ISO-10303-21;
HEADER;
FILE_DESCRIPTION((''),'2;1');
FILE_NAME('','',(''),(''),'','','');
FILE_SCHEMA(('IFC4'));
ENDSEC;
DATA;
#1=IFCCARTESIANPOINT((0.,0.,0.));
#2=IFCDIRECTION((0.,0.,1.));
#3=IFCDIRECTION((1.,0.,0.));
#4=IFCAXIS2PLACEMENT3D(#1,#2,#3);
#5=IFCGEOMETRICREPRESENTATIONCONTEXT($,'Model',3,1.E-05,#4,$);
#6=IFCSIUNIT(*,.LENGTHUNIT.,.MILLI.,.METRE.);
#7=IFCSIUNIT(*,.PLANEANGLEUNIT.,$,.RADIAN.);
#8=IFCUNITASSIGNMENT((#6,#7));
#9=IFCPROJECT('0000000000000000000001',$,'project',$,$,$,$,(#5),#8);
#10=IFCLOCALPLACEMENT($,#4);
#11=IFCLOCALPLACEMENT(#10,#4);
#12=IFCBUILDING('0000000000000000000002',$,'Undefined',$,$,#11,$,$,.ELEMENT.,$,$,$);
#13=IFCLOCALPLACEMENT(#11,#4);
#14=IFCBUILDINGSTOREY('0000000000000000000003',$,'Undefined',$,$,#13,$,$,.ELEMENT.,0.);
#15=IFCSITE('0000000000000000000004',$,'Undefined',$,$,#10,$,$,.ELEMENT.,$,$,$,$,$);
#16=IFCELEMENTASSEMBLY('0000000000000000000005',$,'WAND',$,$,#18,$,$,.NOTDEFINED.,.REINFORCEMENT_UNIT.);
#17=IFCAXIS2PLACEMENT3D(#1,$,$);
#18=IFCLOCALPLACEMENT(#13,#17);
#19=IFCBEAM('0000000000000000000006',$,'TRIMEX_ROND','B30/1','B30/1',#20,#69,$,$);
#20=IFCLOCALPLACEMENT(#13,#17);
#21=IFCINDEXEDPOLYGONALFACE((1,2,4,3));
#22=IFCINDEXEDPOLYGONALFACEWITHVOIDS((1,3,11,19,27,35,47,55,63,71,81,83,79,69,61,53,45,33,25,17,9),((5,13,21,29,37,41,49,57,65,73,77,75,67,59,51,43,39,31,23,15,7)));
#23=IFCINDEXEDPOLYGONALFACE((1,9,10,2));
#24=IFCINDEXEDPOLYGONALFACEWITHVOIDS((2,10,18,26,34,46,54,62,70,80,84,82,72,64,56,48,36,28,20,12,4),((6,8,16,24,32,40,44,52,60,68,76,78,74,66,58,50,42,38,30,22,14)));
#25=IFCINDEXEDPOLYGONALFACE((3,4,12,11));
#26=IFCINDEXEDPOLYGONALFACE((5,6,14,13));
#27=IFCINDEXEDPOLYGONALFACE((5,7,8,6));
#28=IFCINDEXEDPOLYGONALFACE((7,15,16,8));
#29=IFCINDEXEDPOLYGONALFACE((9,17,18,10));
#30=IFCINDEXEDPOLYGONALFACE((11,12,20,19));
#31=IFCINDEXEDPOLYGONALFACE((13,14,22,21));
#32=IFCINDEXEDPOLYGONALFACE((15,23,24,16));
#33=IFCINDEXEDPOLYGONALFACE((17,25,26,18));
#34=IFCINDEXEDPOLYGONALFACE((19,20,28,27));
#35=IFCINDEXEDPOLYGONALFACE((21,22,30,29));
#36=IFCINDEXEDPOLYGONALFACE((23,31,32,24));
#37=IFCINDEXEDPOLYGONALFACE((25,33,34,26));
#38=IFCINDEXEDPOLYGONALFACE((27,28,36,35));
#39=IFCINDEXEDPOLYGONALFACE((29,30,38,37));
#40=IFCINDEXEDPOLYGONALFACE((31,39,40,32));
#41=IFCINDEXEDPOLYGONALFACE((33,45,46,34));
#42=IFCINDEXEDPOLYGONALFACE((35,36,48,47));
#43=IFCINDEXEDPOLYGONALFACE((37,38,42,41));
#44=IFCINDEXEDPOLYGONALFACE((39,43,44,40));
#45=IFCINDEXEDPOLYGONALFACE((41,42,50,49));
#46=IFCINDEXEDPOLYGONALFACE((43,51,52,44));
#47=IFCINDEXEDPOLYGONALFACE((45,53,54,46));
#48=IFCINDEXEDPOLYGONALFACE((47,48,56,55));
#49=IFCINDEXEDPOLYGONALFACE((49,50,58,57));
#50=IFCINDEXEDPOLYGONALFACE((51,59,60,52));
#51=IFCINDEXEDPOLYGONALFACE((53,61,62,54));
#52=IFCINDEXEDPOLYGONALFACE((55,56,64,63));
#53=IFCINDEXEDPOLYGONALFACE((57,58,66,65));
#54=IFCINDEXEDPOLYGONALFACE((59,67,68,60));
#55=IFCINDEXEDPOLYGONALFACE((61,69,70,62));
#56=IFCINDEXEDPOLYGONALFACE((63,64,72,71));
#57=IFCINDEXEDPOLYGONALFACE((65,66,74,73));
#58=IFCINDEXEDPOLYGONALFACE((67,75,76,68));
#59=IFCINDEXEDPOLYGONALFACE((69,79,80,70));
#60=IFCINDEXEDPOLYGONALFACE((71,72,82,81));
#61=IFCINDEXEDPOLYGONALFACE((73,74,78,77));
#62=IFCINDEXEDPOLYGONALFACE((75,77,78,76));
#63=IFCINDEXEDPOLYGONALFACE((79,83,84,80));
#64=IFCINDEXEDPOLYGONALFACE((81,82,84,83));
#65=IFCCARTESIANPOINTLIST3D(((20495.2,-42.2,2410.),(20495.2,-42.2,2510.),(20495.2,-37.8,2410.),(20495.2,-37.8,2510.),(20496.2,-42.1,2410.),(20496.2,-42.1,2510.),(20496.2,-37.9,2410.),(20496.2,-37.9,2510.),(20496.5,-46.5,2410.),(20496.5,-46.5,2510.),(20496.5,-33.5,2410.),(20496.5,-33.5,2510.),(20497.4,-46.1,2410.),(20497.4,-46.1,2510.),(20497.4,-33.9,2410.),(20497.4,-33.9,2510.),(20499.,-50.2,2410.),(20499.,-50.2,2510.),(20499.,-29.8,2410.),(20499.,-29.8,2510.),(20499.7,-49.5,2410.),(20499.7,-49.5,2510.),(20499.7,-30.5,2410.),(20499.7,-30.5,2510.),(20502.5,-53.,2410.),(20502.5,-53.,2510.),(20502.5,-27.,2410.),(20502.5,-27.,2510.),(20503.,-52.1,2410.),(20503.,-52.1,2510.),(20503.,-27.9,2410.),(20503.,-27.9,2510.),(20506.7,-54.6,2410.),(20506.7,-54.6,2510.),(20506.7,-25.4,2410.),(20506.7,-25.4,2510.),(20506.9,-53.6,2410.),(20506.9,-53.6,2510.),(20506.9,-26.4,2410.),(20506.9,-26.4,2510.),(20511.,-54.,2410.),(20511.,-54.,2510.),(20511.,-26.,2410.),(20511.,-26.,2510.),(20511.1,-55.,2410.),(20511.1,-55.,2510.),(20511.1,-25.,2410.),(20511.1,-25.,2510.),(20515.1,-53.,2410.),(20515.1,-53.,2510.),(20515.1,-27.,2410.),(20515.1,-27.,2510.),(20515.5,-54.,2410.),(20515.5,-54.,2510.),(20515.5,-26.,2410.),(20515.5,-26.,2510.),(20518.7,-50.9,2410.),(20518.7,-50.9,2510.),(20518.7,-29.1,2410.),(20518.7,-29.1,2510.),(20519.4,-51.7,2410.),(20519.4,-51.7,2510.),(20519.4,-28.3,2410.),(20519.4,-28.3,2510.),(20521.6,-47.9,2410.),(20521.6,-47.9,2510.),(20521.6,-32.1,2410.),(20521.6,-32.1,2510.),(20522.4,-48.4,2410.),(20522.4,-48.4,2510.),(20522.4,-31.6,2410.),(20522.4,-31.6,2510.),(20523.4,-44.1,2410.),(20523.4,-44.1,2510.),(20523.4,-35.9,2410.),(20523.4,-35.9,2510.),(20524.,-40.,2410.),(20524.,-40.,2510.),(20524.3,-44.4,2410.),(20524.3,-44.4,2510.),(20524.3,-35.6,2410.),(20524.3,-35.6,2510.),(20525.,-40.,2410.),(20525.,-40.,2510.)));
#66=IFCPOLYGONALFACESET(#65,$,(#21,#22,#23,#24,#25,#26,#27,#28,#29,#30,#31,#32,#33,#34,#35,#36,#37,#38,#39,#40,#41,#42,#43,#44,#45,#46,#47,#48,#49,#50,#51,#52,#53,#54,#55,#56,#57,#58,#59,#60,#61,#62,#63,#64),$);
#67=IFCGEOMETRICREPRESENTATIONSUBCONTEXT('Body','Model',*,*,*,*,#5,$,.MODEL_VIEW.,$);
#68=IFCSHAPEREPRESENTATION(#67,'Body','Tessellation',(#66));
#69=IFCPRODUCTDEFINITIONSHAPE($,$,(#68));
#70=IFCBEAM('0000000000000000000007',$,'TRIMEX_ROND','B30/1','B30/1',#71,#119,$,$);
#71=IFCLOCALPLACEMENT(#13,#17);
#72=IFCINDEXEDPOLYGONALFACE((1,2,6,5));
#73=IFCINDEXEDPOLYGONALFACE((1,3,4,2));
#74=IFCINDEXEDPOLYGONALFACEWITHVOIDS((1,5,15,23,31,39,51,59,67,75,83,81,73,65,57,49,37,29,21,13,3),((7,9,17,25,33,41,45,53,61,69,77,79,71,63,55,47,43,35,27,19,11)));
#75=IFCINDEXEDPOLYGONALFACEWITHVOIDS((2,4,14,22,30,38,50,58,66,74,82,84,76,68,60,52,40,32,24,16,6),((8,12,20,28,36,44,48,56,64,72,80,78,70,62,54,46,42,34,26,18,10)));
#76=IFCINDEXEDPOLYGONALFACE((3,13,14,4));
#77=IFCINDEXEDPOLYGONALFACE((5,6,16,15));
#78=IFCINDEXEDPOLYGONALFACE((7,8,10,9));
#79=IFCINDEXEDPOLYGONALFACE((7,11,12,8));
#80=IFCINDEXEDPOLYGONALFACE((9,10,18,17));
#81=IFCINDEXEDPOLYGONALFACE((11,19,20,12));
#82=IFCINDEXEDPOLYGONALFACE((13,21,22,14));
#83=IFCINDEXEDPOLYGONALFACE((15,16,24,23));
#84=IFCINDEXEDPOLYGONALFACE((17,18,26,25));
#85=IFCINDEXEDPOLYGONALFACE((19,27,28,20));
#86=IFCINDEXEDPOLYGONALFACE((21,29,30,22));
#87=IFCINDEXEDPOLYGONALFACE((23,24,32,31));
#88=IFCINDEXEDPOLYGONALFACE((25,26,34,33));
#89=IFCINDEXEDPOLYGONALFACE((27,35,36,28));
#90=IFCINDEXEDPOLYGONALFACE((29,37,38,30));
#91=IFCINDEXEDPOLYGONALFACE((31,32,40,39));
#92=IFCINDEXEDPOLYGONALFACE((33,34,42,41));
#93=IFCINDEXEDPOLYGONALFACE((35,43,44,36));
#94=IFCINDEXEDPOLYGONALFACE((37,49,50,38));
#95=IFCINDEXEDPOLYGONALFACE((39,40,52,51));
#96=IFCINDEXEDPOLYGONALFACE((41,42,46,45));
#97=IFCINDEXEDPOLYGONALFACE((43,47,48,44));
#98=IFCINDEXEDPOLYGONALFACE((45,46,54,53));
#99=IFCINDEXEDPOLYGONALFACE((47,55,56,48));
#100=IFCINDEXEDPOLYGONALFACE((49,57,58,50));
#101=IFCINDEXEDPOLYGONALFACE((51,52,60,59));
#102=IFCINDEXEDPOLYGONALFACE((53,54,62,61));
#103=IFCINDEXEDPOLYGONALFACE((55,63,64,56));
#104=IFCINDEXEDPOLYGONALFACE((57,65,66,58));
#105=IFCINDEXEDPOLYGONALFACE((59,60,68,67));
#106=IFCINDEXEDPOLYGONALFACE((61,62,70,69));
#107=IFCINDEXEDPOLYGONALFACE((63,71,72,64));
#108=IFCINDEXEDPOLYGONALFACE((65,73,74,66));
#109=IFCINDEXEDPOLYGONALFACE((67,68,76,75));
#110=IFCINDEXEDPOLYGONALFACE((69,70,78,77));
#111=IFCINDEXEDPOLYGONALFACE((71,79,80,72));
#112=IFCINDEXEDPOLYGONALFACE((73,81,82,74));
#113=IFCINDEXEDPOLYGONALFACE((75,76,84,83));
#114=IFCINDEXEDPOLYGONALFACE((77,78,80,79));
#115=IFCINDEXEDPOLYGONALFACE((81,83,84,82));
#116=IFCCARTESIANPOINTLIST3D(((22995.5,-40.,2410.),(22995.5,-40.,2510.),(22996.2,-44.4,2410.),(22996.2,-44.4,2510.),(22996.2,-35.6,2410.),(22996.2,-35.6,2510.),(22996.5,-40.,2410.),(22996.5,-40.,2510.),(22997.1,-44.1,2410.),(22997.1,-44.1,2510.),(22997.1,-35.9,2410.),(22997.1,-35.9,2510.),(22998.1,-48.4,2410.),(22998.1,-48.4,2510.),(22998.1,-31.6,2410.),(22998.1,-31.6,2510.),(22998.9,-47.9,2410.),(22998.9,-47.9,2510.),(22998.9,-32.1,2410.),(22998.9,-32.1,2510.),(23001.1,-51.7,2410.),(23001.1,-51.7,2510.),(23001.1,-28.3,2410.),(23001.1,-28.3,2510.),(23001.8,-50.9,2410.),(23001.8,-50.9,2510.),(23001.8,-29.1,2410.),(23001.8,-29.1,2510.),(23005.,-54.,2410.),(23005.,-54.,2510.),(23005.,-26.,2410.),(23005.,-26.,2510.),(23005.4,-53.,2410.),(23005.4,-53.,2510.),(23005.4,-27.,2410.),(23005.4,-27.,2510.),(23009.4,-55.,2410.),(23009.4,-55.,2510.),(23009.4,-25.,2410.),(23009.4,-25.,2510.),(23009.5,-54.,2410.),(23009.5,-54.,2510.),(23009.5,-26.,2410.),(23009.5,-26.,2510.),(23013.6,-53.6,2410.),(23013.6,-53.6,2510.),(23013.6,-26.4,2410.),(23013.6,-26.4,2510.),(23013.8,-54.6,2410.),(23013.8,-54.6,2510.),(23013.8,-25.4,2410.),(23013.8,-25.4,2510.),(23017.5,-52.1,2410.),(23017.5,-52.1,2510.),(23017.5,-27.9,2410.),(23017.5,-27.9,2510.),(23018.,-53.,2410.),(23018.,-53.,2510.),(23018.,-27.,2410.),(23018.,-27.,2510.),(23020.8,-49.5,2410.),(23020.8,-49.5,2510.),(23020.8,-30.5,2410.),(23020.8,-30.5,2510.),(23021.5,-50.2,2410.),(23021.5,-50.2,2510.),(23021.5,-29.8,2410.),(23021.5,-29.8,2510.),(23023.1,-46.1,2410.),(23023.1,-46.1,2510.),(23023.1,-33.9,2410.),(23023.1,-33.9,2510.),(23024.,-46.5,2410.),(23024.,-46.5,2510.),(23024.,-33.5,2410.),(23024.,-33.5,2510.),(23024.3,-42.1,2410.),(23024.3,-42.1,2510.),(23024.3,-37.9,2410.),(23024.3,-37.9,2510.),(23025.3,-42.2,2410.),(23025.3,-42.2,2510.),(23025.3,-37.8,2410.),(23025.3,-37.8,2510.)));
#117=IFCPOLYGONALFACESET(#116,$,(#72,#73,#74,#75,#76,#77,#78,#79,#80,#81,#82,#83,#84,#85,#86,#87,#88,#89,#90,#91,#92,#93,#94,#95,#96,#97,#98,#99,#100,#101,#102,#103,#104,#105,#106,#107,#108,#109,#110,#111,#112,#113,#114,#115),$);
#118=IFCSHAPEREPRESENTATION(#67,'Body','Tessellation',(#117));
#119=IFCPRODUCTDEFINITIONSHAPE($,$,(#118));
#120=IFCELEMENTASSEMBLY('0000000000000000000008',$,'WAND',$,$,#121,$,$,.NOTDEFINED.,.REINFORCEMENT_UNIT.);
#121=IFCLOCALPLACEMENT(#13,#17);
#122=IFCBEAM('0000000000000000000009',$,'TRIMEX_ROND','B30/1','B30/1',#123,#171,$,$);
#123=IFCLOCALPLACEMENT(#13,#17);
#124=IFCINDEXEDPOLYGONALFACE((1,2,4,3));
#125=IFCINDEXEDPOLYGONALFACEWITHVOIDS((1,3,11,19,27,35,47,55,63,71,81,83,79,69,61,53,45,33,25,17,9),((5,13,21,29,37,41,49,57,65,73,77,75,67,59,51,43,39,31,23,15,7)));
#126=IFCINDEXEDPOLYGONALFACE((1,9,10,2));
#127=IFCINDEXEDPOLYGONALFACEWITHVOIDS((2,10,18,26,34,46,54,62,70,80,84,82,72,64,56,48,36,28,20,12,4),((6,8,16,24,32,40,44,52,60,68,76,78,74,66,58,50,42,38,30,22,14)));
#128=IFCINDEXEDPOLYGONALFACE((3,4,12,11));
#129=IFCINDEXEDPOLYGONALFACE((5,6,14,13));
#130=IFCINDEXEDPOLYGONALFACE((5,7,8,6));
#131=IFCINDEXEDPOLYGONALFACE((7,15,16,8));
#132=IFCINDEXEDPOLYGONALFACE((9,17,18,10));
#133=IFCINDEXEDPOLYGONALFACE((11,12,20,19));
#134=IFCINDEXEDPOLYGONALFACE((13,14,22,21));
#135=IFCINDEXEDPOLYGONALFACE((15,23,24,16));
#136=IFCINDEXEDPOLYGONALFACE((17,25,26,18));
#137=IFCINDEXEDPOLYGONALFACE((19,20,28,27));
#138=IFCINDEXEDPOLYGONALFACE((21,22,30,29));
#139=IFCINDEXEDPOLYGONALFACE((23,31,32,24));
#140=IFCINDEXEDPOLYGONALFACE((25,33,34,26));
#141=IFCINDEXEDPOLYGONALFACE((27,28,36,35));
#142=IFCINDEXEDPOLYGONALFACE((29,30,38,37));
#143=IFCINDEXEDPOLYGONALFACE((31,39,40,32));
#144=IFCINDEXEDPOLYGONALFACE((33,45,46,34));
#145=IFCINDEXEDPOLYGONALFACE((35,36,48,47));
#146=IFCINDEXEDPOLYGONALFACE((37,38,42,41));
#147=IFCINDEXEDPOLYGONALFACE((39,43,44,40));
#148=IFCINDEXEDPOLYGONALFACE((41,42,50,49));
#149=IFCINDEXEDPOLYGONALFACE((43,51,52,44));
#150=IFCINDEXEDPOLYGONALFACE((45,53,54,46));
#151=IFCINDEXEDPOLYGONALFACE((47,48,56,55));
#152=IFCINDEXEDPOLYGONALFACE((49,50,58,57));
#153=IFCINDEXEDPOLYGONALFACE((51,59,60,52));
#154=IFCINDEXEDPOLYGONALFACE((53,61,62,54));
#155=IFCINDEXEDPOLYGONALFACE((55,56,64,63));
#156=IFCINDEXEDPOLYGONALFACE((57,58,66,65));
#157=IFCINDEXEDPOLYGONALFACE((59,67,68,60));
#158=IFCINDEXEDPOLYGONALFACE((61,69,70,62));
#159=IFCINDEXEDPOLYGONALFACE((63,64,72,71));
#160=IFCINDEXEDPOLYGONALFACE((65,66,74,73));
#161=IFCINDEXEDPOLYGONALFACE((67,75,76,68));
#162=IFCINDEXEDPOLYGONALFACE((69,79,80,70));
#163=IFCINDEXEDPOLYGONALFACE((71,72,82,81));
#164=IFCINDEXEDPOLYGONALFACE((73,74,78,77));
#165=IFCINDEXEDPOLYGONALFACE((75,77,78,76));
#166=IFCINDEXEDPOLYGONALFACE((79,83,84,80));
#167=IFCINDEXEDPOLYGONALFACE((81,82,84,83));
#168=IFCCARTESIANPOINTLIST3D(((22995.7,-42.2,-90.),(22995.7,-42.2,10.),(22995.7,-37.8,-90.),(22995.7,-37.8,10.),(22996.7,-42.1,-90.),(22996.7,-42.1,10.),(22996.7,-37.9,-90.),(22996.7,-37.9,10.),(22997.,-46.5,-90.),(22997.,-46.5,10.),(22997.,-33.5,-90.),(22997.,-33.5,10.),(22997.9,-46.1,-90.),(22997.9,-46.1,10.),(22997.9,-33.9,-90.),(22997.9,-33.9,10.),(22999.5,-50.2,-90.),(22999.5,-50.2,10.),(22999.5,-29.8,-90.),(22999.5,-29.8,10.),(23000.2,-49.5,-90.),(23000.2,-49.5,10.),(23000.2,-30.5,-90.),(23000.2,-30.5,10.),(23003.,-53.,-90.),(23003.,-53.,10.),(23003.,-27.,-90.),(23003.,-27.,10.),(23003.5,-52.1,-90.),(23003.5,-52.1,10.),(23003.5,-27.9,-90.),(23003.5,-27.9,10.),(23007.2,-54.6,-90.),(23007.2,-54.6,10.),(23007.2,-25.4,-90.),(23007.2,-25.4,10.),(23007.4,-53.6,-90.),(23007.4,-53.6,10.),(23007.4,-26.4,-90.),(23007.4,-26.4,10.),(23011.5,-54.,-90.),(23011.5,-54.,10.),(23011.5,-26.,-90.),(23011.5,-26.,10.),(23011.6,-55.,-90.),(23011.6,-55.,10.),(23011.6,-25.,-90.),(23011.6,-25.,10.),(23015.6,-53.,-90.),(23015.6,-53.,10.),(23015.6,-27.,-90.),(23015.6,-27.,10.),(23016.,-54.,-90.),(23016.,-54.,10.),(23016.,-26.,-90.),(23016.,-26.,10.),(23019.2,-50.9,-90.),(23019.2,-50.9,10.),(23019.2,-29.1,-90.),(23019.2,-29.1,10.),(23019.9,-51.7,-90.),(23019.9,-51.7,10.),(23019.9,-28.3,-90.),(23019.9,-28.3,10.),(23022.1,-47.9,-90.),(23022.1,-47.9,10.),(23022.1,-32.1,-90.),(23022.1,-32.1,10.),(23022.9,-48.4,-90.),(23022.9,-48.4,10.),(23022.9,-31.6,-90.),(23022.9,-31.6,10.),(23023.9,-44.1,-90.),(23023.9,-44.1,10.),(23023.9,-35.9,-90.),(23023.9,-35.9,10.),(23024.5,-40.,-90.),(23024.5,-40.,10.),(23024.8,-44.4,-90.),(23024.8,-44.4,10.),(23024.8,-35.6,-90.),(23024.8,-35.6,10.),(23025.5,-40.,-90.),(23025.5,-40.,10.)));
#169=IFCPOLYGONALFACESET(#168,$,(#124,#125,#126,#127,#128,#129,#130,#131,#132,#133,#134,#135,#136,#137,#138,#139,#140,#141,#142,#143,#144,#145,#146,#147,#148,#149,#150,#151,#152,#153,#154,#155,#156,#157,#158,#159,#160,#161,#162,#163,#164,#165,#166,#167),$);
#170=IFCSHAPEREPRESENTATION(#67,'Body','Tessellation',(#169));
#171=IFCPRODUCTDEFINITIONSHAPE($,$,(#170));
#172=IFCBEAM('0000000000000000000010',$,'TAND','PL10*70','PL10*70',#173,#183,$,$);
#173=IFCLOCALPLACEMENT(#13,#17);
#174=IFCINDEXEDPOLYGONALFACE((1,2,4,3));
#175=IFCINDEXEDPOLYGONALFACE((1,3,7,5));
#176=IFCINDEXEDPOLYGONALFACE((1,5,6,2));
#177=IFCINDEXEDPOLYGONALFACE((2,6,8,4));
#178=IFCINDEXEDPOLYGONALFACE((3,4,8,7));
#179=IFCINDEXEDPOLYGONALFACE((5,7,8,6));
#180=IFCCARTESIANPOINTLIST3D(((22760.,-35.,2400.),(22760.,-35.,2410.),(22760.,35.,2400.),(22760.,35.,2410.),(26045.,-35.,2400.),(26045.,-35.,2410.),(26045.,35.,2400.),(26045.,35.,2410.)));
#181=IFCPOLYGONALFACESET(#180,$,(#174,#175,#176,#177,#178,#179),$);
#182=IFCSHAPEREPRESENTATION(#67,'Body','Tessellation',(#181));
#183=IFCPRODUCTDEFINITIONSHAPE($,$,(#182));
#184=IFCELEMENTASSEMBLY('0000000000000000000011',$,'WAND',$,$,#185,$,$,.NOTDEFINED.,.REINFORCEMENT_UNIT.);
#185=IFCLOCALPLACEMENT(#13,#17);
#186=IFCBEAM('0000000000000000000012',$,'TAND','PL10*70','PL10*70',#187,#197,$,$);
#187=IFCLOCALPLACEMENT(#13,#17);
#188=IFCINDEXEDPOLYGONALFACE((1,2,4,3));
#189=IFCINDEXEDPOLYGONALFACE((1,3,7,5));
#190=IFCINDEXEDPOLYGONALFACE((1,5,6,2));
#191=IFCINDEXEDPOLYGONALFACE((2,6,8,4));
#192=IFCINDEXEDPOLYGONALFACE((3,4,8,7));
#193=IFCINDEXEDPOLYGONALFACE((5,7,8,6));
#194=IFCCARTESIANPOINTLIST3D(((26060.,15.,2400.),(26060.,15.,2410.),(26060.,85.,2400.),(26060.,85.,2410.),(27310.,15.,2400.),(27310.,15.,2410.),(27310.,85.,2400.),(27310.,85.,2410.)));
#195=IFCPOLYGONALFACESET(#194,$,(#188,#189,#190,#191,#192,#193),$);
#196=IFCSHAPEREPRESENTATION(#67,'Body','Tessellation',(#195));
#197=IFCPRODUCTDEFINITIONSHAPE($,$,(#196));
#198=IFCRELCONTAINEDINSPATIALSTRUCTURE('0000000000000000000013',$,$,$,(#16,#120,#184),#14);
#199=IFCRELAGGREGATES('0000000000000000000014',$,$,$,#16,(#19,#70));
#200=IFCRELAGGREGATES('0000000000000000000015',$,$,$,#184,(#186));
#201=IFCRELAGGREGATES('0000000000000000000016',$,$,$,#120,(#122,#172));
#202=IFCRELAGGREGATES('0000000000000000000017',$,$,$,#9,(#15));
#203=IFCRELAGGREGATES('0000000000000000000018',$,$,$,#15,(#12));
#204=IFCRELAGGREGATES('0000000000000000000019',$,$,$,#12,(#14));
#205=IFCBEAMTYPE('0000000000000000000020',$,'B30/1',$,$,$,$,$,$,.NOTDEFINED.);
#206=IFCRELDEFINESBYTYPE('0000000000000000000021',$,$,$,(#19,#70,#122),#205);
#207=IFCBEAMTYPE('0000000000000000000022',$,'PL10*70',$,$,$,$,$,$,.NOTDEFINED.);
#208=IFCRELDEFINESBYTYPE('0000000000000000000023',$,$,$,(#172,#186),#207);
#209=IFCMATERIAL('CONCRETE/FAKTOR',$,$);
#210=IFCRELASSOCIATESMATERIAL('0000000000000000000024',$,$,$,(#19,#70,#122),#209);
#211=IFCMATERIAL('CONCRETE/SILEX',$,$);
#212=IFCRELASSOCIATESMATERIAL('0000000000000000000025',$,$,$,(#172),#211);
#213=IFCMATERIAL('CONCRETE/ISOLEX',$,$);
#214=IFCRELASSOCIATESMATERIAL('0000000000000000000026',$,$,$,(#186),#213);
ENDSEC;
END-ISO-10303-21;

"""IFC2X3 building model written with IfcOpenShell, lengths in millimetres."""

from ifc_helpers import new_model, si_unit, frame, frame_2d, origin_with_axes, place, context, subcontext, project, spatial, rectangle, hollow_circle, extrude, material, type_object, element, aggregate, save


model = new_model("IFC2X3")

# Units and contexts
model_context = context("Model", 3, precision=1e-05, world=origin_with_axes())
body_context = subcontext(model_context, "Body", "Model", "MODEL_VIEW")
ifc_project = project(units=[si_unit("LENGTHUNIT", "METRE", prefix="MILLI"), si_unit("PLANEANGLEUNIT", "RADIAN")], contexts=[model_context])

# Site, building, storey
site_placement = place(None, origin_with_axes())
site = spatial("IfcSite", under=ifc_project, at=site_placement, Name="Undefined", CompositionType="ELEMENT")
building_placement = place(site_placement, origin_with_axes())
building = spatial("IfcBuilding", under=site, at=building_placement, Name="Undefined", CompositionType="ELEMENT")
storey_placement = place(building_placement, origin_with_axes())
storey = spatial("IfcBuildingStorey", under=building, at=storey_placement, Name="Undefined", CompositionType="ELEMENT", Elevation=0.0)

# Shared definitions
ifc_material_1 = material(Name="CONCRETE/FAKTOR")

# Element assemblies, beams
assembly_1_placement = place(storey_placement, origin_with_axes())
assembly_1 = element("IfcElementAssembly", 1, at=assembly_1_placement, inside=storey, Name="WAND", AssemblyPlace="NOTDEFINED", PredefinedType="REINFORCEMENT_UNIT")
beam_type_1 = type_object("IfcBeamType", Name="B30/1", PredefinedType="NOTDEFINED")
beam_1_placement = place(assembly_1_placement, frame((20510.0, -40.0, 2410.0), z_axis=(0.0, -1.0, 0.0), x_axis=(0.0, 0.0, 1.0)))
beam_1 = element("IfcBeam", 2, at=beam_1_placement, type_object=beam_type_1, material=ifc_material_1, Name="TRIMEX_ROND", Description="B30/1", ObjectType="B30/1", context=body_context, shape_type="SweptSolid", body=[
    extrude(hollow_circle(Radius=15.0, WallThickness=1.0, at=frame_2d((0.0, 0.0), x_axis=(1.0, 0.0))), frame((100.0, 0.0, 0.0), z_axis=(-1.0, 0.0, 0.0), x_axis=(0.0, -1.0, 0.0)), (0.0, 0.0, 1.0), 100.0),
])
beam_2_placement = place(assembly_1_placement, frame((23010.5, -40.0, 2410.0), z_axis=(0.0, 1.0, 0.0), x_axis=(0.0, 0.0, 1.0)))
beam_2 = element("IfcBeam", 3, at=beam_2_placement, type_object=beam_type_1, material=ifc_material_1, Name="TRIMEX_ROND", Description="B30/1", ObjectType="B30/1", context=body_context, shape_type="SweptSolid", body=[
    extrude(hollow_circle(Radius=15.0, WallThickness=1.0, at=frame_2d((0.0, 0.0), x_axis=(1.0, 0.0))), frame((100.0, 0.0, 0.0), z_axis=(-1.0, 0.0, 0.0), x_axis=(0.0, -1.0, 0.0)), (0.0, 0.0, 1.0), 100.0),
])
aggregate(assembly_1, [beam_1, beam_2])
assembly_2_placement = place(storey_placement, origin_with_axes())
assembly_2 = element("IfcElementAssembly", 4, at=assembly_2_placement, inside=storey, Name="WAND", AssemblyPlace="NOTDEFINED", PredefinedType="REINFORCEMENT_UNIT")
beam_3_placement = place(assembly_2_placement, frame((23010.5, -40.0, -90.0), z_axis=(0.0, -1.0, 0.0), x_axis=(0.0, 0.0, 1.0)))
beam_3 = element("IfcBeam", 5, at=beam_3_placement, type_object=beam_type_1, material=ifc_material_1, Name="TRIMEX_ROND", Description="B30/1", ObjectType="B30/1", context=body_context, shape_type="SweptSolid", body=[
    extrude(hollow_circle(Radius=15.0, WallThickness=1.0, at=frame_2d((0.0, 0.0), x_axis=(1.0, 0.0))), frame((100.0, 0.0, 0.0), z_axis=(-1.0, 0.0, 0.0), x_axis=(0.0, -1.0, 0.0)), (0.0, 0.0, 1.0), 100.0),
])
ifc_material_2 = material(Name="CONCRETE/SILEX")
beam_type_2 = type_object("IfcBeamType", Name="PL10*70", PredefinedType="NOTDEFINED")
beam_4_placement = place(assembly_2_placement, frame((22760.0, 0.0, 2405.0), z_axis=(0.0, -1.0, 0.0), x_axis=(1.0, 0.0, 0.0)))
beam_4 = element("IfcBeam", 6, at=beam_4_placement, type_object=beam_type_2, material=ifc_material_2, Name="TAND", Description="PL10*70", ObjectType="PL10*70", context=body_context, shape_type="SweptSolid", body=[
    extrude(rectangle(XDim=10.0, YDim=70.0, at=frame_2d((0.0, 0.0), x_axis=(1.0, 0.0))), frame((3285.0, 0.0, 0.0), z_axis=(-1.0, 0.0, 0.0), x_axis=(0.0, -1.0, 0.0)), (0.0, 0.0, 1.0), 3285.0),
])

# Element assembly, beam
assembly_3_placement = place(storey_placement, origin_with_axes())
assembly_3 = element("IfcElementAssembly", 7, at=assembly_3_placement, inside=storey, Name="WAND", AssemblyPlace="NOTDEFINED", PredefinedType="REINFORCEMENT_UNIT")
ifc_material_3 = material(Name="CONCRETE/ISOLEX")
beam_5_placement = place(assembly_3_placement, frame((26060.0, 50.0, 2405.0), z_axis=(0.0, -1.0, 0.0), x_axis=(1.0, 0.0, 0.0)))
beam_5 = element("IfcBeam", 8, at=beam_5_placement, type_object=beam_type_2, material=ifc_material_3, Name="TAND", Description="PL10*70", ObjectType="PL10*70", context=body_context, shape_type="SweptSolid", body=[
    extrude(rectangle(XDim=10.0, YDim=70.0, at=frame_2d((0.0, 0.0), x_axis=(1.0, 0.0))), frame((1250.0, 0.0, 0.0), z_axis=(-1.0, 0.0, 0.0), x_axis=(0.0, -1.0, 0.0)), (0.0, 0.0, 1.0), 1250.0),
])

aggregate(assembly_3, [beam_5])

aggregate(assembly_2, [beam_3, beam_4])

save(model, "model.ifc")
